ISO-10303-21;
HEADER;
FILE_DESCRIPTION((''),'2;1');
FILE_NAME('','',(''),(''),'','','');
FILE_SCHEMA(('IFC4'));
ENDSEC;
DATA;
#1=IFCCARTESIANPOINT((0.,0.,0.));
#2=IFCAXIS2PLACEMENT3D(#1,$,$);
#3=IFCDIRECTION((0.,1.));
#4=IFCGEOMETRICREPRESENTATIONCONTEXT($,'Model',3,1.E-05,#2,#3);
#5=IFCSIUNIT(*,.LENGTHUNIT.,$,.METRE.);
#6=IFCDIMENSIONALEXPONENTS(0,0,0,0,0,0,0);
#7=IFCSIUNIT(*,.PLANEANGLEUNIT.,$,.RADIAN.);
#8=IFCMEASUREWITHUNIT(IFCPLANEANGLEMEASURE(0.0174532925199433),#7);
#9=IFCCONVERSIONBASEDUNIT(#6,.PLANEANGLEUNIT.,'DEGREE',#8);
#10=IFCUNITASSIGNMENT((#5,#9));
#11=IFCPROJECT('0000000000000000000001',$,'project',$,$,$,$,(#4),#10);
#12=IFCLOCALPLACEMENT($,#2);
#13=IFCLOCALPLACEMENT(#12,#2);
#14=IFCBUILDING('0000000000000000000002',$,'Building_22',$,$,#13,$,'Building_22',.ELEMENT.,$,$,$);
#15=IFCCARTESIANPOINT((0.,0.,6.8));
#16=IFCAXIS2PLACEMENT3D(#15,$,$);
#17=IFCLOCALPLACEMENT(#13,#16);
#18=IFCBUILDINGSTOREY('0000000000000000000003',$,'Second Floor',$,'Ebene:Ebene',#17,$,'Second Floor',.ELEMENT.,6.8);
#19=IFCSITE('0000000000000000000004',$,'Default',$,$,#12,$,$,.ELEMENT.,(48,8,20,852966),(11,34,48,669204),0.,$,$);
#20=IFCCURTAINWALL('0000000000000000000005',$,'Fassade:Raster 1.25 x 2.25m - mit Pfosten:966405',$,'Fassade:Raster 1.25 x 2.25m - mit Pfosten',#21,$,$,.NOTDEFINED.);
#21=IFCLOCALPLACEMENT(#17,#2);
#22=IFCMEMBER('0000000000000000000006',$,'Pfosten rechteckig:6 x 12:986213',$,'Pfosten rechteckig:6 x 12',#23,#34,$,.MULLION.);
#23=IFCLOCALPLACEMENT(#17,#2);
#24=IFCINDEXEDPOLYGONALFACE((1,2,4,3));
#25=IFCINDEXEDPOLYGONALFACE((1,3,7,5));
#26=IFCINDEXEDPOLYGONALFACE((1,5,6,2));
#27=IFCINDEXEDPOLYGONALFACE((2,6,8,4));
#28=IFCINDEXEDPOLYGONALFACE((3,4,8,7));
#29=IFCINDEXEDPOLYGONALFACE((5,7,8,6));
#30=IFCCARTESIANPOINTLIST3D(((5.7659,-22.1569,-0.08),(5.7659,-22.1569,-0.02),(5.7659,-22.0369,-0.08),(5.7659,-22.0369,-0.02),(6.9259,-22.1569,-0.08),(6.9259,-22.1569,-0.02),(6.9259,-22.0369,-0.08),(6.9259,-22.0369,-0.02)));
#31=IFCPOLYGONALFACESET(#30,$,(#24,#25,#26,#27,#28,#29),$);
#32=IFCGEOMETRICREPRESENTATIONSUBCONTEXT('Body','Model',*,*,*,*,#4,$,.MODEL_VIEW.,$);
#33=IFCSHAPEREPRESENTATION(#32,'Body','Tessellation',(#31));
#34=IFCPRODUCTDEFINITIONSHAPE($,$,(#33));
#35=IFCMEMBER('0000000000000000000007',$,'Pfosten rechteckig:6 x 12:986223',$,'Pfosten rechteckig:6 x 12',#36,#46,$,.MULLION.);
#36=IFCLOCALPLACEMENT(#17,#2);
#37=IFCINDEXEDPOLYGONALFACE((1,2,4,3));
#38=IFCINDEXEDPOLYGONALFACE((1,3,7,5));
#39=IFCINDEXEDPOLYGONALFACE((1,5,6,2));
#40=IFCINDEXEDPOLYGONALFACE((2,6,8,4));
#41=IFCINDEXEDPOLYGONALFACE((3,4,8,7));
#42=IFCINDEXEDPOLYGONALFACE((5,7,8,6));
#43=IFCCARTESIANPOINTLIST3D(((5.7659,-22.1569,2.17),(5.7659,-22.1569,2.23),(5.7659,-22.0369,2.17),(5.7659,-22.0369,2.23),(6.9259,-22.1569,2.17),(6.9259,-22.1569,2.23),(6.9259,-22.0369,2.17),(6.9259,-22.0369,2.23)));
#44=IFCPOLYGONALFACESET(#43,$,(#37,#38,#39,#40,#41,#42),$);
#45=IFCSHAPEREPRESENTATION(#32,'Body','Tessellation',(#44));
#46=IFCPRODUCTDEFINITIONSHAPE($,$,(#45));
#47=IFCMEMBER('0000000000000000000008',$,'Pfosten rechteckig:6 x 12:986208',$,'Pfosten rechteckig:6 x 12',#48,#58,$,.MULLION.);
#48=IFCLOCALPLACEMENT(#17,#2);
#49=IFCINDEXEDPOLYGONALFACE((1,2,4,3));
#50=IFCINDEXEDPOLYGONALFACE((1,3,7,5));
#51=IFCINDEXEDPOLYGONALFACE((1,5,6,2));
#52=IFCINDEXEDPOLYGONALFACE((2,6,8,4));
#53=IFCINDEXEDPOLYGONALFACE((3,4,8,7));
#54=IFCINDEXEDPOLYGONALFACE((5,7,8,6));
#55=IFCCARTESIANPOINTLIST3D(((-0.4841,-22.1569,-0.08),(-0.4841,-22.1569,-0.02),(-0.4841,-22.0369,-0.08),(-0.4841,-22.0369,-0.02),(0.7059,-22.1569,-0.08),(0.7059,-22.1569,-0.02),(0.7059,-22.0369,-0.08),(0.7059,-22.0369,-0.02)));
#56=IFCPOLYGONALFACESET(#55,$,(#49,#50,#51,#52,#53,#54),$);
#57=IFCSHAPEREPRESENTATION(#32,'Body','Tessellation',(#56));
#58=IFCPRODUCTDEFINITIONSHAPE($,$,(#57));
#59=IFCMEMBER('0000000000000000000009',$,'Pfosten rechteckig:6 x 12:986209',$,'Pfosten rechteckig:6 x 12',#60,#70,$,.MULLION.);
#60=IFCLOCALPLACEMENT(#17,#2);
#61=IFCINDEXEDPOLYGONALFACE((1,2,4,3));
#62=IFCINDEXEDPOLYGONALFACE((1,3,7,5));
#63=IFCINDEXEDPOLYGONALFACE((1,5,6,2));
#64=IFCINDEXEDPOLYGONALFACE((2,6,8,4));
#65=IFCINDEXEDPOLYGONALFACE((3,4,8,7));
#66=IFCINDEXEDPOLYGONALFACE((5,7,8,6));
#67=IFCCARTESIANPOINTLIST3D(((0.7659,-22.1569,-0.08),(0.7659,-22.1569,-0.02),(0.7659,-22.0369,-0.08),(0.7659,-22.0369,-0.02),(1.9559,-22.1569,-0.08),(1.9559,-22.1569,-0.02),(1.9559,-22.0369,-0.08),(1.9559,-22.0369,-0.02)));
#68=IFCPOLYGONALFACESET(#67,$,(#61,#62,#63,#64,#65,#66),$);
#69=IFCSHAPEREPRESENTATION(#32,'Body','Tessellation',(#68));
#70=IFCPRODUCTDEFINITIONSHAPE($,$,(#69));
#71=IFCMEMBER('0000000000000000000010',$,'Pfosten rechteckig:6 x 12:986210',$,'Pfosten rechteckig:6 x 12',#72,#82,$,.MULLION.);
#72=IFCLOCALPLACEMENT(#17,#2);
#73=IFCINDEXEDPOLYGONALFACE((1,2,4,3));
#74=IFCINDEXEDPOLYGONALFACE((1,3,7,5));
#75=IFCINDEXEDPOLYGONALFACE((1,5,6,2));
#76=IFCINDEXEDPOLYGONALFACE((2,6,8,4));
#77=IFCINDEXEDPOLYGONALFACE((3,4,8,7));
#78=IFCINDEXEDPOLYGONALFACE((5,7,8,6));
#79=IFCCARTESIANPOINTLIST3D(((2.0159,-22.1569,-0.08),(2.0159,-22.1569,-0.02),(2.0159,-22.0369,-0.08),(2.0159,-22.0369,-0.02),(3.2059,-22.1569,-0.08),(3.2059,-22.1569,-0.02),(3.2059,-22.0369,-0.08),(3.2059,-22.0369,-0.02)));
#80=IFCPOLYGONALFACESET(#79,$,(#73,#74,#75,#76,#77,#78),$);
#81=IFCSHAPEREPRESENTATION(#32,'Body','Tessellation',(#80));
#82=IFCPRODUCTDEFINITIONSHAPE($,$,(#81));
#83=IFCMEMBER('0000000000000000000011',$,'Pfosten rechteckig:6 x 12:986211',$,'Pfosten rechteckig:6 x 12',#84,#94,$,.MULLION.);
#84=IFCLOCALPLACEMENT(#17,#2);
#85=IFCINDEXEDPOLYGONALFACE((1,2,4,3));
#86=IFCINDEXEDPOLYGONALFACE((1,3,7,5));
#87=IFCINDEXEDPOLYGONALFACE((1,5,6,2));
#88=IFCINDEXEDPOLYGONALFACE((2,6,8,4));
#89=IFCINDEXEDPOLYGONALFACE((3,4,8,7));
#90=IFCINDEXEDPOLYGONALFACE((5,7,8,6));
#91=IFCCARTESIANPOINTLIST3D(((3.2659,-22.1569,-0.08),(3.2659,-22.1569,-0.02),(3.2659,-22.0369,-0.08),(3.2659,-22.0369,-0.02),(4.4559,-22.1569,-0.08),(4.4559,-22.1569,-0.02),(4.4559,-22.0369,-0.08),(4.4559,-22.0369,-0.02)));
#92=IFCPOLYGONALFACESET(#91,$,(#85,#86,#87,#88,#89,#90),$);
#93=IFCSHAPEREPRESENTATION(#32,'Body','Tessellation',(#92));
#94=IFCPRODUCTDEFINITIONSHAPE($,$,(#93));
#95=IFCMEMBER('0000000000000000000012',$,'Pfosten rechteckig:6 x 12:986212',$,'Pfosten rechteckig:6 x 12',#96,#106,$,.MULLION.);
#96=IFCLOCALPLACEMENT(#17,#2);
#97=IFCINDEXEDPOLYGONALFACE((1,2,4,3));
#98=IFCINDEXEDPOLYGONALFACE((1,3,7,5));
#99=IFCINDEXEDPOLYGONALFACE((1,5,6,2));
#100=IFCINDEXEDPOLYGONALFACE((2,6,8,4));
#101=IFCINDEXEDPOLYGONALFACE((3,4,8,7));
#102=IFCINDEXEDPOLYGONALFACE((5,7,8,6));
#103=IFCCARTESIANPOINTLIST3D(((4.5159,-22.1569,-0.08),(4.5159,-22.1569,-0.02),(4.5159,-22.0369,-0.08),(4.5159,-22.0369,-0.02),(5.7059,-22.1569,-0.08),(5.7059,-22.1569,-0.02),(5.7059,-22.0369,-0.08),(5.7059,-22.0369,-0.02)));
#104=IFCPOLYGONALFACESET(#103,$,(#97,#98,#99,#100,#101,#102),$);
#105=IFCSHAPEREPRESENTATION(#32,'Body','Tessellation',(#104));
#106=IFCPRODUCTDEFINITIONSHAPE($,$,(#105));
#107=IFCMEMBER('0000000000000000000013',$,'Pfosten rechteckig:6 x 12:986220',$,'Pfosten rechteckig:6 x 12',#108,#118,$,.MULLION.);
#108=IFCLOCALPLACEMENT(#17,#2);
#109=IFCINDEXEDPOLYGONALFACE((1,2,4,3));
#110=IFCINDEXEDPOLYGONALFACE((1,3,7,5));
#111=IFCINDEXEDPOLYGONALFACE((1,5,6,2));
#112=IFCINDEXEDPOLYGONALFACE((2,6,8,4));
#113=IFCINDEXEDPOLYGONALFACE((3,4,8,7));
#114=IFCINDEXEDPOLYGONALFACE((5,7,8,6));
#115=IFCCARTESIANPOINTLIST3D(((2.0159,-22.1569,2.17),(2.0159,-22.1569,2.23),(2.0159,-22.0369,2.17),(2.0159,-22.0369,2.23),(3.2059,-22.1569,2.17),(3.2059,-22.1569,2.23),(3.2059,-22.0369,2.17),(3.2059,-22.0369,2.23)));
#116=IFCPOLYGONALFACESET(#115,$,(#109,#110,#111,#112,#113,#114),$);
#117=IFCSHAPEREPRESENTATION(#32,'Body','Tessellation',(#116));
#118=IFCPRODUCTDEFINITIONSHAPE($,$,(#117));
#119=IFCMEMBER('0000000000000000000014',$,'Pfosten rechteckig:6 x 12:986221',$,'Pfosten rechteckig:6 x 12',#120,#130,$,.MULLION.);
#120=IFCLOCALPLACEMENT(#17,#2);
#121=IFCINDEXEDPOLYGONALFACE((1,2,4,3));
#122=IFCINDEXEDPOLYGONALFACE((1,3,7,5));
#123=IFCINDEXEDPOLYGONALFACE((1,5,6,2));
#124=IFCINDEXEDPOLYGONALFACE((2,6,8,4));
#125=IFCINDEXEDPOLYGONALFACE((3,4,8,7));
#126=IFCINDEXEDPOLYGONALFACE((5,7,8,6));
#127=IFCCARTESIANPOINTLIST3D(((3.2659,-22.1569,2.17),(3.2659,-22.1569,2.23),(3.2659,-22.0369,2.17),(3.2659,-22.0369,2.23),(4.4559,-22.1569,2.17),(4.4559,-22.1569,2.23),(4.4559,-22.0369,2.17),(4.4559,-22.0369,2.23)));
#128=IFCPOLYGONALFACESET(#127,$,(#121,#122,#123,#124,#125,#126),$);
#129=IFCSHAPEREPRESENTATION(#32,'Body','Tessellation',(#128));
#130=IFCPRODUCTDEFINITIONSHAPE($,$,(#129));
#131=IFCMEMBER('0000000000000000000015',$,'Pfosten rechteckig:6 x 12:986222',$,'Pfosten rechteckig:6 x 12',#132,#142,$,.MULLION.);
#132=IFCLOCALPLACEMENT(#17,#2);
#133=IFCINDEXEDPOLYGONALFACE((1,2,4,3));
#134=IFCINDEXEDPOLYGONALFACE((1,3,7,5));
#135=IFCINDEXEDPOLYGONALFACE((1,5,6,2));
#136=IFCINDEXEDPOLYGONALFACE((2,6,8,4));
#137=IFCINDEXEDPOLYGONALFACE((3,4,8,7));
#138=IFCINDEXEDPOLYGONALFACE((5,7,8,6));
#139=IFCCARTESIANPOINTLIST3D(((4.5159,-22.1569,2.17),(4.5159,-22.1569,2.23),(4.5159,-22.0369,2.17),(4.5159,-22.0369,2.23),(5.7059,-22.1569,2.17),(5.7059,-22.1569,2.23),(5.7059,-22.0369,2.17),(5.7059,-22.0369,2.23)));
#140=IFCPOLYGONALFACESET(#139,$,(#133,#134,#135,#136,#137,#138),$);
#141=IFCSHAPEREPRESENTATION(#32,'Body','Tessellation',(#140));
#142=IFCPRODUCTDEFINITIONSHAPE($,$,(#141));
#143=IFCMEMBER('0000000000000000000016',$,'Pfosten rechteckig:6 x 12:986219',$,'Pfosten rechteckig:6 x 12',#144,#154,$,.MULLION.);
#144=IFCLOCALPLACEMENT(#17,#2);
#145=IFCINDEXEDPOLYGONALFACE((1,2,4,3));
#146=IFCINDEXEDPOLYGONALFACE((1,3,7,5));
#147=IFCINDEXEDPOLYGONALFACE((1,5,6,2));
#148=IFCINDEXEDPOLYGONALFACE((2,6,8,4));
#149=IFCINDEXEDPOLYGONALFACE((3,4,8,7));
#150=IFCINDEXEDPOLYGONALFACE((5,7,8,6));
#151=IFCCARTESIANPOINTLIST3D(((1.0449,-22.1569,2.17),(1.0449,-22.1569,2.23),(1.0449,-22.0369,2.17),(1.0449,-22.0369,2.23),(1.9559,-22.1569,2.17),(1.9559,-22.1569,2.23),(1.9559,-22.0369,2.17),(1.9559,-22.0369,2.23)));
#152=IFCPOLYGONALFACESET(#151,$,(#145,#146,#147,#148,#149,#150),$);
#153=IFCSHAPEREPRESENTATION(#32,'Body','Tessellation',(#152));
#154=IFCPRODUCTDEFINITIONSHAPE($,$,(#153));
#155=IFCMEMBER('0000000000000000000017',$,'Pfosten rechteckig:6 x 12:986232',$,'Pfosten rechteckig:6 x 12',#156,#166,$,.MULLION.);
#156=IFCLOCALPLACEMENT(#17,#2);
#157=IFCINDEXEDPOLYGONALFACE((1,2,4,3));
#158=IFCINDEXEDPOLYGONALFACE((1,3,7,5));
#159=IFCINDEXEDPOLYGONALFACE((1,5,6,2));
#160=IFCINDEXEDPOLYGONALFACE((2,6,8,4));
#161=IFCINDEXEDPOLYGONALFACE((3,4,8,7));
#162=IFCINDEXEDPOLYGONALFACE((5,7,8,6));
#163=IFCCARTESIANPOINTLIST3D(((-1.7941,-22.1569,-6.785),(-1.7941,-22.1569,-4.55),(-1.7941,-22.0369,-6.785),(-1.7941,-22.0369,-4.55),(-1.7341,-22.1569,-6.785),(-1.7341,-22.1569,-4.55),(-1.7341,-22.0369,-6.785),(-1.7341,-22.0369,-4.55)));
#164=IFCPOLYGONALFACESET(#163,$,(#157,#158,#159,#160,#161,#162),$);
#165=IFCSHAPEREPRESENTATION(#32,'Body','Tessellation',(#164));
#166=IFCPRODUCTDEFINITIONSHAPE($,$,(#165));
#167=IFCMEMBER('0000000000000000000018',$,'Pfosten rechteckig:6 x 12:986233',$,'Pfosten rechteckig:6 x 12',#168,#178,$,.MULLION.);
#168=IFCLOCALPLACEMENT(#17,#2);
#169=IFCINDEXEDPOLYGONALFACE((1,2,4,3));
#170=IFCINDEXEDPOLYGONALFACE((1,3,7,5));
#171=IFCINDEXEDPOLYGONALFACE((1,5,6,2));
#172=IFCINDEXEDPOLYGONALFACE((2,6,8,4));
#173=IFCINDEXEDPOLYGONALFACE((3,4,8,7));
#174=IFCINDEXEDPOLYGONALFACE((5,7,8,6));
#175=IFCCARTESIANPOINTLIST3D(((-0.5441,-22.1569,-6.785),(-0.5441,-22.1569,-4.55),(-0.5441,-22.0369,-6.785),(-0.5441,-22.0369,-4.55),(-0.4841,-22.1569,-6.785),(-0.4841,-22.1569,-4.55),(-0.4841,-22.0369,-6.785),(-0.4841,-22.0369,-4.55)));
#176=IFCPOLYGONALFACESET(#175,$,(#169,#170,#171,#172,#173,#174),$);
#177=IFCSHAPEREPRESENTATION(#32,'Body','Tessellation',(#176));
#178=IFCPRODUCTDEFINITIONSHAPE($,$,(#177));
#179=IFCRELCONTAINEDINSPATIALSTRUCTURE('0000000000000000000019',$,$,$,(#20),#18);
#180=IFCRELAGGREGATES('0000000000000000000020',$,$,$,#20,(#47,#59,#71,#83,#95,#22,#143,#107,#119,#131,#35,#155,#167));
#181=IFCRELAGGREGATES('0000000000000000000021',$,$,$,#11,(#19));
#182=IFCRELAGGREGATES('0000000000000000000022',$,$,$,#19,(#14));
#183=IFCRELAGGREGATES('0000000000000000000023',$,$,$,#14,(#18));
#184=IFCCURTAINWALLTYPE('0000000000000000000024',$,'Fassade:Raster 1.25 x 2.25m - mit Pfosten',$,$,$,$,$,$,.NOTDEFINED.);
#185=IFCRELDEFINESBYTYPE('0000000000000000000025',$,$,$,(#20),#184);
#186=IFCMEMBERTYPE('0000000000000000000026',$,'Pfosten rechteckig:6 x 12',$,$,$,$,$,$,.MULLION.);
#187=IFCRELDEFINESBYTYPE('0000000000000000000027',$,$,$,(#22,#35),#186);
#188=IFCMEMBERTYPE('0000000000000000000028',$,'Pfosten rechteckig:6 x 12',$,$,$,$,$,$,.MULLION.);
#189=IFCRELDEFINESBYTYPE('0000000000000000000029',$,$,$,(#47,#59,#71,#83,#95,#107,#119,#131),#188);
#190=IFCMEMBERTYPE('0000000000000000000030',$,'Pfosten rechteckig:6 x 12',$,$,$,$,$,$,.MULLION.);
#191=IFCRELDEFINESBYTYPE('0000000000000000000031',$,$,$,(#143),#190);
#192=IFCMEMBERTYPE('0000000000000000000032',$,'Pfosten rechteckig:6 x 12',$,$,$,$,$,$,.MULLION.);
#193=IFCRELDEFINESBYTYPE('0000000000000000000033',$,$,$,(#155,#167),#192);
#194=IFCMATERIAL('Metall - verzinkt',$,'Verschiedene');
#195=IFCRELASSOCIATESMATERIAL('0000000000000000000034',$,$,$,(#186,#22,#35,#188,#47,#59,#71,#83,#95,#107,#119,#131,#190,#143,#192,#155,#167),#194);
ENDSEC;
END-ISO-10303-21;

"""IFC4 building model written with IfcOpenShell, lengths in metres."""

from ifc_helpers import new_model, entity, si_unit, converted_unit, direction, frame, origin, place, context, subcontext, project, spatial, indexed_curve, outline, extrude, source, transform, mapped, material, type_object, type_shapes, element, aggregate, save


model = new_model("IFC4")

# Units and contexts
model_context = context("Model", 3, precision=1e-05, world=origin(), true_north=direction((0.0, 1.0)))
body_context = subcontext(model_context, "Body", "Model", "MODEL_VIEW")
ifc_project = project(units=[si_unit("LENGTHUNIT", "METRE"), converted_unit("PLANEANGLEUNIT", "DEGREE", entity("IfcPlaneAngleMeasure", 0.0174532925199433), si_unit("PLANEANGLEUNIT", "RADIAN"), dimensions=[0, 0, 0, 0, 0, 0, 0])], contexts=[model_context])

# Site, building, storey
site_placement = place(None, origin())
site = spatial("IfcSite", under=ifc_project, at=site_placement, Name="Default", CompositionType="ELEMENT", RefLatitude=(48, 8, 20, 852966), RefLongitude=(11, 34, 48, 669204), RefElevation=0.0)
building_placement = place(site_placement, origin())
building = spatial("IfcBuilding", under=site, at=building_placement, Name="Building_22", LongName="Building_22", CompositionType="ELEMENT")
storey_placement = place(building_placement, frame((0.0, 0.0, 6.8)))
storey = spatial("IfcBuildingStorey", under=building, at=storey_placement, Name="Second Floor", ObjectType="Ebene:Ebene", LongName="Second Floor", CompositionType="ELEMENT", Elevation=6.8)

# Curtain wall, members
curtain_wall_type = type_object("IfcCurtainWallType", Name="Fassade:Raster 1.25 x 2.25m - mit Pfosten", PredefinedType="NOTDEFINED")
curtain_wall_placement = place(storey_placement, frame((0.0, 0.0, -6.8)))
curtain_wall = element("IfcCurtainWall", 1, at=curtain_wall_placement, inside=storey, type_object=curtain_wall_type, Name="Fassade:Raster 1.25 x 2.25m - mit Pfosten:966405", ObjectType="Fassade:Raster 1.25 x 2.25m - mit Pfosten", PredefinedType="NOTDEFINED")
ifc_material = material(Name="Metall - verzinkt", Category="Verschiedene")
member_type_1 = type_object("IfcMemberType", Name="Pfosten rechteckig:6 x 12", PredefinedType="MULLION", material=ifc_material)
shared_shape_1 = source(origin(), body_context, "Body", "SweptSolid", [
    extrude(outline(indexed_curve([(-0.03, -0.06), (0.03, -0.06), (0.03, 0.06), (-0.03, 0.06), (-0.03, -0.06)], self_intersect=False)), frame((0.0, 0.0, -1.16), z_axis=(0.0, 0.0, 1.0), x_axis=(-1.0, 0.0, 0.0)), (0.0, 0.0, 1.0), 1.16),
])
type_shapes(member_type_1, [shared_shape_1])
member_1_placement = place(curtain_wall_placement, frame((6.9259, -22.0969, 6.75), z_axis=(1.0, 0.0, 0.0), x_axis=(0.0, 0.0, 1.0)))
member_1 = element("IfcMember", 2, at=member_1_placement, type_object=member_type_1, material=ifc_material, Name="Pfosten rechteckig:6 x 12:986213", ObjectType="Pfosten rechteckig:6 x 12", PredefinedType="MULLION", context=body_context, shape_type="MappedRepresentation", body=[
    mapped(shared_shape_1, transform((0.0, 0.0, 0.0), scale=1.0)),
])
member_2_placement = place(curtain_wall_placement, frame((6.9259, -22.0969, 9.0), z_axis=(1.0, 0.0, 0.0), x_axis=(0.0, 0.0, 1.0)))
member_2 = element("IfcMember", 3, at=member_2_placement, type_object=member_type_1, material=ifc_material, Name="Pfosten rechteckig:6 x 12:986223", ObjectType="Pfosten rechteckig:6 x 12", PredefinedType="MULLION", context=body_context, shape_type="MappedRepresentation", body=[
    mapped(shared_shape_1, transform((0.0, 0.0, 0.0), scale=1.0)),
])
member_type_2 = type_object("IfcMemberType", Name="Pfosten rechteckig:6 x 12", PredefinedType="MULLION", material=ifc_material)
shared_shape_2 = source(origin(), body_context, "Body", "SweptSolid", [
    extrude(outline(indexed_curve([(-0.03, -0.06), (0.03, -0.06), (0.03, 0.06), (-0.03, 0.06), (-0.03, -0.06)], self_intersect=False)), frame((0.0, 0.0, -1.19), z_axis=(0.0, 0.0, 1.0), x_axis=(-1.0, 0.0, 0.0)), (0.0, 0.0, 1.0), 1.19),
])
type_shapes(member_type_2, [shared_shape_2])
member_3_placement = place(curtain_wall_placement, frame((0.7059, -22.0969, 6.75), z_axis=(1.0, 0.0, 0.0), x_axis=(0.0, 0.0, 1.0)))
member_3 = element("IfcMember", 4, at=member_3_placement, type_object=member_type_2, material=ifc_material, Name="Pfosten rechteckig:6 x 12:986208", ObjectType="Pfosten rechteckig:6 x 12", PredefinedType="MULLION", context=body_context, shape_type="MappedRepresentation", body=[
    mapped(shared_shape_2, transform((0.0, 0.0, 0.0), scale=1.0)),
])
member_4_placement = place(curtain_wall_placement, frame((1.9559, -22.0969, 6.75), z_axis=(1.0, 0.0, 0.0), x_axis=(0.0, 0.0, 1.0)))
member_4 = element("IfcMember", 5, at=member_4_placement, type_object=member_type_2, material=ifc_material, Name="Pfosten rechteckig:6 x 12:986209", ObjectType="Pfosten rechteckig:6 x 12", PredefinedType="MULLION", context=body_context, shape_type="MappedRepresentation", body=[
    mapped(shared_shape_2, transform((0.0, 0.0, 0.0), scale=1.0)),
])
member_5_placement = place(curtain_wall_placement, frame((3.2059, -22.0969, 6.75), z_axis=(1.0, 0.0, 0.0), x_axis=(0.0, 0.0, 1.0)))
member_5 = element("IfcMember", 6, at=member_5_placement, type_object=member_type_2, material=ifc_material, Name="Pfosten rechteckig:6 x 12:986210", ObjectType="Pfosten rechteckig:6 x 12", PredefinedType="MULLION", context=body_context, shape_type="MappedRepresentation", body=[
    mapped(shared_shape_2, transform((0.0, 0.0, 0.0), scale=1.0)),
])
member_6_placement = place(curtain_wall_placement, frame((4.4559, -22.0969, 6.75), z_axis=(1.0, 0.0, 0.0), x_axis=(0.0, 0.0, 1.0)))
member_6 = element("IfcMember", 7, at=member_6_placement, type_object=member_type_2, material=ifc_material, Name="Pfosten rechteckig:6 x 12:986211", ObjectType="Pfosten rechteckig:6 x 12", PredefinedType="MULLION", context=body_context, shape_type="MappedRepresentation", body=[
    mapped(shared_shape_2, transform((0.0, 0.0, 0.0), scale=1.0)),
])
member_7_placement = place(curtain_wall_placement, frame((5.7059, -22.0969, 6.75), z_axis=(1.0, 0.0, 0.0), x_axis=(0.0, 0.0, 1.0)))
member_7 = element("IfcMember", 8, at=member_7_placement, type_object=member_type_2, material=ifc_material, Name="Pfosten rechteckig:6 x 12:986212", ObjectType="Pfosten rechteckig:6 x 12", PredefinedType="MULLION", context=body_context, shape_type="MappedRepresentation", body=[
    mapped(shared_shape_2, transform((0.0, 0.0, 0.0), scale=1.0)),
])
member_8_placement = place(curtain_wall_placement, frame((3.2059, -22.0969, 9.0), z_axis=(1.0, 0.0, 0.0), x_axis=(0.0, 0.0, 1.0)))
member_8 = element("IfcMember", 9, at=member_8_placement, type_object=member_type_2, material=ifc_material, Name="Pfosten rechteckig:6 x 12:986220", ObjectType="Pfosten rechteckig:6 x 12", PredefinedType="MULLION", context=body_context, shape_type="MappedRepresentation", body=[
    mapped(shared_shape_2, transform((0.0, 0.0, 0.0), scale=1.0)),
])
member_9_placement = place(curtain_wall_placement, frame((4.4559, -22.0969, 9.0), z_axis=(1.0, 0.0, 0.0), x_axis=(0.0, 0.0, 1.0)))
member_9 = element("IfcMember", 10, at=member_9_placement, type_object=member_type_2, material=ifc_material, Name="Pfosten rechteckig:6 x 12:986221", ObjectType="Pfosten rechteckig:6 x 12", PredefinedType="MULLION", context=body_context, shape_type="MappedRepresentation", body=[
    mapped(shared_shape_2, transform((0.0, 0.0, 0.0), scale=1.0)),
])
member_10_placement = place(curtain_wall_placement, frame((5.7059, -22.0969, 9.0), z_axis=(1.0, 0.0, 0.0), x_axis=(0.0, 0.0, 1.0)))
member_10 = element("IfcMember", 11, at=member_10_placement, type_object=member_type_2, material=ifc_material, Name="Pfosten rechteckig:6 x 12:986222", ObjectType="Pfosten rechteckig:6 x 12", PredefinedType="MULLION", context=body_context, shape_type="MappedRepresentation", body=[
    mapped(shared_shape_2, transform((0.0, 0.0, 0.0), scale=1.0)),
])
member_type_3 = type_object("IfcMemberType", Name="Pfosten rechteckig:6 x 12", PredefinedType="MULLION", material=ifc_material)
shared_shape_3 = source(origin(), body_context, "Body", "SweptSolid", [
    extrude(outline(indexed_curve([(-0.03, -0.06), (0.03, -0.06), (0.03, 0.06), (-0.03, 0.06), (-0.03, -0.06)], self_intersect=False)), frame((0.0, 0.0, -0.911), z_axis=(0.0, 0.0, 1.0), x_axis=(-1.0, 0.0, 0.0)), (0.0, 0.0, 1.0), 0.911),
])
type_shapes(member_type_3, [shared_shape_3])
member_11_placement = place(curtain_wall_placement, frame((1.9559, -22.0969, 9.0), z_axis=(1.0, 0.0, 0.0), x_axis=(0.0, 0.0, 1.0)))
member_11 = element("IfcMember", 12, at=member_11_placement, type_object=member_type_3, material=ifc_material, Name="Pfosten rechteckig:6 x 12:986219", ObjectType="Pfosten rechteckig:6 x 12", PredefinedType="MULLION", context=body_context, shape_type="MappedRepresentation", body=[
    mapped(shared_shape_3, transform((0.0, 0.0, 0.0), scale=1.0)),
])
member_type_4 = type_object("IfcMemberType", Name="Pfosten rechteckig:6 x 12", PredefinedType="MULLION", material=ifc_material)
shared_shape_4 = source(origin(), body_context, "Body", "SweptSolid", [
    extrude(outline(indexed_curve([(-0.03, -0.06), (0.03, -0.06), (0.03, 0.06), (-0.03, 0.06), (-0.03, -0.06)], self_intersect=False)), frame((0.0, 0.0, -2.235), z_axis=(0.0, 0.0, 1.0), x_axis=(-1.0, 0.0, 0.0)), (0.0, 0.0, 1.0), 2.235),
])
type_shapes(member_type_4, [shared_shape_4])
member_12_placement = place(curtain_wall_placement, frame((-1.7641, -22.0969, 0.015), z_axis=(0.0, 0.0, -1.0), x_axis=(1.0, 0.0, 0.0)))
member_12 = element("IfcMember", 13, at=member_12_placement, type_object=member_type_4, material=ifc_material, Name="Pfosten rechteckig:6 x 12:986232", ObjectType="Pfosten rechteckig:6 x 12", PredefinedType="MULLION", context=body_context, shape_type="MappedRepresentation", body=[
    mapped(shared_shape_4, transform((0.0, 0.0, 0.0), scale=1.0)),
])
member_13_placement = place(curtain_wall_placement, frame((-0.5141, -22.0969, 0.015), z_axis=(0.0, 0.0, -1.0), x_axis=(1.0, 0.0, 0.0)))
member_13 = element("IfcMember", 14, at=member_13_placement, type_object=member_type_4, material=ifc_material, Name="Pfosten rechteckig:6 x 12:986233", ObjectType="Pfosten rechteckig:6 x 12", PredefinedType="MULLION", context=body_context, shape_type="MappedRepresentation", body=[
    mapped(shared_shape_4, transform((0.0, 0.0, 0.0), scale=1.0)),
])
aggregate(curtain_wall, [member_3, member_4, member_5, member_6, member_7, member_1, member_11, member_8, member_9, member_10, member_2, member_12, member_13])

save(model, "model.ifc")
